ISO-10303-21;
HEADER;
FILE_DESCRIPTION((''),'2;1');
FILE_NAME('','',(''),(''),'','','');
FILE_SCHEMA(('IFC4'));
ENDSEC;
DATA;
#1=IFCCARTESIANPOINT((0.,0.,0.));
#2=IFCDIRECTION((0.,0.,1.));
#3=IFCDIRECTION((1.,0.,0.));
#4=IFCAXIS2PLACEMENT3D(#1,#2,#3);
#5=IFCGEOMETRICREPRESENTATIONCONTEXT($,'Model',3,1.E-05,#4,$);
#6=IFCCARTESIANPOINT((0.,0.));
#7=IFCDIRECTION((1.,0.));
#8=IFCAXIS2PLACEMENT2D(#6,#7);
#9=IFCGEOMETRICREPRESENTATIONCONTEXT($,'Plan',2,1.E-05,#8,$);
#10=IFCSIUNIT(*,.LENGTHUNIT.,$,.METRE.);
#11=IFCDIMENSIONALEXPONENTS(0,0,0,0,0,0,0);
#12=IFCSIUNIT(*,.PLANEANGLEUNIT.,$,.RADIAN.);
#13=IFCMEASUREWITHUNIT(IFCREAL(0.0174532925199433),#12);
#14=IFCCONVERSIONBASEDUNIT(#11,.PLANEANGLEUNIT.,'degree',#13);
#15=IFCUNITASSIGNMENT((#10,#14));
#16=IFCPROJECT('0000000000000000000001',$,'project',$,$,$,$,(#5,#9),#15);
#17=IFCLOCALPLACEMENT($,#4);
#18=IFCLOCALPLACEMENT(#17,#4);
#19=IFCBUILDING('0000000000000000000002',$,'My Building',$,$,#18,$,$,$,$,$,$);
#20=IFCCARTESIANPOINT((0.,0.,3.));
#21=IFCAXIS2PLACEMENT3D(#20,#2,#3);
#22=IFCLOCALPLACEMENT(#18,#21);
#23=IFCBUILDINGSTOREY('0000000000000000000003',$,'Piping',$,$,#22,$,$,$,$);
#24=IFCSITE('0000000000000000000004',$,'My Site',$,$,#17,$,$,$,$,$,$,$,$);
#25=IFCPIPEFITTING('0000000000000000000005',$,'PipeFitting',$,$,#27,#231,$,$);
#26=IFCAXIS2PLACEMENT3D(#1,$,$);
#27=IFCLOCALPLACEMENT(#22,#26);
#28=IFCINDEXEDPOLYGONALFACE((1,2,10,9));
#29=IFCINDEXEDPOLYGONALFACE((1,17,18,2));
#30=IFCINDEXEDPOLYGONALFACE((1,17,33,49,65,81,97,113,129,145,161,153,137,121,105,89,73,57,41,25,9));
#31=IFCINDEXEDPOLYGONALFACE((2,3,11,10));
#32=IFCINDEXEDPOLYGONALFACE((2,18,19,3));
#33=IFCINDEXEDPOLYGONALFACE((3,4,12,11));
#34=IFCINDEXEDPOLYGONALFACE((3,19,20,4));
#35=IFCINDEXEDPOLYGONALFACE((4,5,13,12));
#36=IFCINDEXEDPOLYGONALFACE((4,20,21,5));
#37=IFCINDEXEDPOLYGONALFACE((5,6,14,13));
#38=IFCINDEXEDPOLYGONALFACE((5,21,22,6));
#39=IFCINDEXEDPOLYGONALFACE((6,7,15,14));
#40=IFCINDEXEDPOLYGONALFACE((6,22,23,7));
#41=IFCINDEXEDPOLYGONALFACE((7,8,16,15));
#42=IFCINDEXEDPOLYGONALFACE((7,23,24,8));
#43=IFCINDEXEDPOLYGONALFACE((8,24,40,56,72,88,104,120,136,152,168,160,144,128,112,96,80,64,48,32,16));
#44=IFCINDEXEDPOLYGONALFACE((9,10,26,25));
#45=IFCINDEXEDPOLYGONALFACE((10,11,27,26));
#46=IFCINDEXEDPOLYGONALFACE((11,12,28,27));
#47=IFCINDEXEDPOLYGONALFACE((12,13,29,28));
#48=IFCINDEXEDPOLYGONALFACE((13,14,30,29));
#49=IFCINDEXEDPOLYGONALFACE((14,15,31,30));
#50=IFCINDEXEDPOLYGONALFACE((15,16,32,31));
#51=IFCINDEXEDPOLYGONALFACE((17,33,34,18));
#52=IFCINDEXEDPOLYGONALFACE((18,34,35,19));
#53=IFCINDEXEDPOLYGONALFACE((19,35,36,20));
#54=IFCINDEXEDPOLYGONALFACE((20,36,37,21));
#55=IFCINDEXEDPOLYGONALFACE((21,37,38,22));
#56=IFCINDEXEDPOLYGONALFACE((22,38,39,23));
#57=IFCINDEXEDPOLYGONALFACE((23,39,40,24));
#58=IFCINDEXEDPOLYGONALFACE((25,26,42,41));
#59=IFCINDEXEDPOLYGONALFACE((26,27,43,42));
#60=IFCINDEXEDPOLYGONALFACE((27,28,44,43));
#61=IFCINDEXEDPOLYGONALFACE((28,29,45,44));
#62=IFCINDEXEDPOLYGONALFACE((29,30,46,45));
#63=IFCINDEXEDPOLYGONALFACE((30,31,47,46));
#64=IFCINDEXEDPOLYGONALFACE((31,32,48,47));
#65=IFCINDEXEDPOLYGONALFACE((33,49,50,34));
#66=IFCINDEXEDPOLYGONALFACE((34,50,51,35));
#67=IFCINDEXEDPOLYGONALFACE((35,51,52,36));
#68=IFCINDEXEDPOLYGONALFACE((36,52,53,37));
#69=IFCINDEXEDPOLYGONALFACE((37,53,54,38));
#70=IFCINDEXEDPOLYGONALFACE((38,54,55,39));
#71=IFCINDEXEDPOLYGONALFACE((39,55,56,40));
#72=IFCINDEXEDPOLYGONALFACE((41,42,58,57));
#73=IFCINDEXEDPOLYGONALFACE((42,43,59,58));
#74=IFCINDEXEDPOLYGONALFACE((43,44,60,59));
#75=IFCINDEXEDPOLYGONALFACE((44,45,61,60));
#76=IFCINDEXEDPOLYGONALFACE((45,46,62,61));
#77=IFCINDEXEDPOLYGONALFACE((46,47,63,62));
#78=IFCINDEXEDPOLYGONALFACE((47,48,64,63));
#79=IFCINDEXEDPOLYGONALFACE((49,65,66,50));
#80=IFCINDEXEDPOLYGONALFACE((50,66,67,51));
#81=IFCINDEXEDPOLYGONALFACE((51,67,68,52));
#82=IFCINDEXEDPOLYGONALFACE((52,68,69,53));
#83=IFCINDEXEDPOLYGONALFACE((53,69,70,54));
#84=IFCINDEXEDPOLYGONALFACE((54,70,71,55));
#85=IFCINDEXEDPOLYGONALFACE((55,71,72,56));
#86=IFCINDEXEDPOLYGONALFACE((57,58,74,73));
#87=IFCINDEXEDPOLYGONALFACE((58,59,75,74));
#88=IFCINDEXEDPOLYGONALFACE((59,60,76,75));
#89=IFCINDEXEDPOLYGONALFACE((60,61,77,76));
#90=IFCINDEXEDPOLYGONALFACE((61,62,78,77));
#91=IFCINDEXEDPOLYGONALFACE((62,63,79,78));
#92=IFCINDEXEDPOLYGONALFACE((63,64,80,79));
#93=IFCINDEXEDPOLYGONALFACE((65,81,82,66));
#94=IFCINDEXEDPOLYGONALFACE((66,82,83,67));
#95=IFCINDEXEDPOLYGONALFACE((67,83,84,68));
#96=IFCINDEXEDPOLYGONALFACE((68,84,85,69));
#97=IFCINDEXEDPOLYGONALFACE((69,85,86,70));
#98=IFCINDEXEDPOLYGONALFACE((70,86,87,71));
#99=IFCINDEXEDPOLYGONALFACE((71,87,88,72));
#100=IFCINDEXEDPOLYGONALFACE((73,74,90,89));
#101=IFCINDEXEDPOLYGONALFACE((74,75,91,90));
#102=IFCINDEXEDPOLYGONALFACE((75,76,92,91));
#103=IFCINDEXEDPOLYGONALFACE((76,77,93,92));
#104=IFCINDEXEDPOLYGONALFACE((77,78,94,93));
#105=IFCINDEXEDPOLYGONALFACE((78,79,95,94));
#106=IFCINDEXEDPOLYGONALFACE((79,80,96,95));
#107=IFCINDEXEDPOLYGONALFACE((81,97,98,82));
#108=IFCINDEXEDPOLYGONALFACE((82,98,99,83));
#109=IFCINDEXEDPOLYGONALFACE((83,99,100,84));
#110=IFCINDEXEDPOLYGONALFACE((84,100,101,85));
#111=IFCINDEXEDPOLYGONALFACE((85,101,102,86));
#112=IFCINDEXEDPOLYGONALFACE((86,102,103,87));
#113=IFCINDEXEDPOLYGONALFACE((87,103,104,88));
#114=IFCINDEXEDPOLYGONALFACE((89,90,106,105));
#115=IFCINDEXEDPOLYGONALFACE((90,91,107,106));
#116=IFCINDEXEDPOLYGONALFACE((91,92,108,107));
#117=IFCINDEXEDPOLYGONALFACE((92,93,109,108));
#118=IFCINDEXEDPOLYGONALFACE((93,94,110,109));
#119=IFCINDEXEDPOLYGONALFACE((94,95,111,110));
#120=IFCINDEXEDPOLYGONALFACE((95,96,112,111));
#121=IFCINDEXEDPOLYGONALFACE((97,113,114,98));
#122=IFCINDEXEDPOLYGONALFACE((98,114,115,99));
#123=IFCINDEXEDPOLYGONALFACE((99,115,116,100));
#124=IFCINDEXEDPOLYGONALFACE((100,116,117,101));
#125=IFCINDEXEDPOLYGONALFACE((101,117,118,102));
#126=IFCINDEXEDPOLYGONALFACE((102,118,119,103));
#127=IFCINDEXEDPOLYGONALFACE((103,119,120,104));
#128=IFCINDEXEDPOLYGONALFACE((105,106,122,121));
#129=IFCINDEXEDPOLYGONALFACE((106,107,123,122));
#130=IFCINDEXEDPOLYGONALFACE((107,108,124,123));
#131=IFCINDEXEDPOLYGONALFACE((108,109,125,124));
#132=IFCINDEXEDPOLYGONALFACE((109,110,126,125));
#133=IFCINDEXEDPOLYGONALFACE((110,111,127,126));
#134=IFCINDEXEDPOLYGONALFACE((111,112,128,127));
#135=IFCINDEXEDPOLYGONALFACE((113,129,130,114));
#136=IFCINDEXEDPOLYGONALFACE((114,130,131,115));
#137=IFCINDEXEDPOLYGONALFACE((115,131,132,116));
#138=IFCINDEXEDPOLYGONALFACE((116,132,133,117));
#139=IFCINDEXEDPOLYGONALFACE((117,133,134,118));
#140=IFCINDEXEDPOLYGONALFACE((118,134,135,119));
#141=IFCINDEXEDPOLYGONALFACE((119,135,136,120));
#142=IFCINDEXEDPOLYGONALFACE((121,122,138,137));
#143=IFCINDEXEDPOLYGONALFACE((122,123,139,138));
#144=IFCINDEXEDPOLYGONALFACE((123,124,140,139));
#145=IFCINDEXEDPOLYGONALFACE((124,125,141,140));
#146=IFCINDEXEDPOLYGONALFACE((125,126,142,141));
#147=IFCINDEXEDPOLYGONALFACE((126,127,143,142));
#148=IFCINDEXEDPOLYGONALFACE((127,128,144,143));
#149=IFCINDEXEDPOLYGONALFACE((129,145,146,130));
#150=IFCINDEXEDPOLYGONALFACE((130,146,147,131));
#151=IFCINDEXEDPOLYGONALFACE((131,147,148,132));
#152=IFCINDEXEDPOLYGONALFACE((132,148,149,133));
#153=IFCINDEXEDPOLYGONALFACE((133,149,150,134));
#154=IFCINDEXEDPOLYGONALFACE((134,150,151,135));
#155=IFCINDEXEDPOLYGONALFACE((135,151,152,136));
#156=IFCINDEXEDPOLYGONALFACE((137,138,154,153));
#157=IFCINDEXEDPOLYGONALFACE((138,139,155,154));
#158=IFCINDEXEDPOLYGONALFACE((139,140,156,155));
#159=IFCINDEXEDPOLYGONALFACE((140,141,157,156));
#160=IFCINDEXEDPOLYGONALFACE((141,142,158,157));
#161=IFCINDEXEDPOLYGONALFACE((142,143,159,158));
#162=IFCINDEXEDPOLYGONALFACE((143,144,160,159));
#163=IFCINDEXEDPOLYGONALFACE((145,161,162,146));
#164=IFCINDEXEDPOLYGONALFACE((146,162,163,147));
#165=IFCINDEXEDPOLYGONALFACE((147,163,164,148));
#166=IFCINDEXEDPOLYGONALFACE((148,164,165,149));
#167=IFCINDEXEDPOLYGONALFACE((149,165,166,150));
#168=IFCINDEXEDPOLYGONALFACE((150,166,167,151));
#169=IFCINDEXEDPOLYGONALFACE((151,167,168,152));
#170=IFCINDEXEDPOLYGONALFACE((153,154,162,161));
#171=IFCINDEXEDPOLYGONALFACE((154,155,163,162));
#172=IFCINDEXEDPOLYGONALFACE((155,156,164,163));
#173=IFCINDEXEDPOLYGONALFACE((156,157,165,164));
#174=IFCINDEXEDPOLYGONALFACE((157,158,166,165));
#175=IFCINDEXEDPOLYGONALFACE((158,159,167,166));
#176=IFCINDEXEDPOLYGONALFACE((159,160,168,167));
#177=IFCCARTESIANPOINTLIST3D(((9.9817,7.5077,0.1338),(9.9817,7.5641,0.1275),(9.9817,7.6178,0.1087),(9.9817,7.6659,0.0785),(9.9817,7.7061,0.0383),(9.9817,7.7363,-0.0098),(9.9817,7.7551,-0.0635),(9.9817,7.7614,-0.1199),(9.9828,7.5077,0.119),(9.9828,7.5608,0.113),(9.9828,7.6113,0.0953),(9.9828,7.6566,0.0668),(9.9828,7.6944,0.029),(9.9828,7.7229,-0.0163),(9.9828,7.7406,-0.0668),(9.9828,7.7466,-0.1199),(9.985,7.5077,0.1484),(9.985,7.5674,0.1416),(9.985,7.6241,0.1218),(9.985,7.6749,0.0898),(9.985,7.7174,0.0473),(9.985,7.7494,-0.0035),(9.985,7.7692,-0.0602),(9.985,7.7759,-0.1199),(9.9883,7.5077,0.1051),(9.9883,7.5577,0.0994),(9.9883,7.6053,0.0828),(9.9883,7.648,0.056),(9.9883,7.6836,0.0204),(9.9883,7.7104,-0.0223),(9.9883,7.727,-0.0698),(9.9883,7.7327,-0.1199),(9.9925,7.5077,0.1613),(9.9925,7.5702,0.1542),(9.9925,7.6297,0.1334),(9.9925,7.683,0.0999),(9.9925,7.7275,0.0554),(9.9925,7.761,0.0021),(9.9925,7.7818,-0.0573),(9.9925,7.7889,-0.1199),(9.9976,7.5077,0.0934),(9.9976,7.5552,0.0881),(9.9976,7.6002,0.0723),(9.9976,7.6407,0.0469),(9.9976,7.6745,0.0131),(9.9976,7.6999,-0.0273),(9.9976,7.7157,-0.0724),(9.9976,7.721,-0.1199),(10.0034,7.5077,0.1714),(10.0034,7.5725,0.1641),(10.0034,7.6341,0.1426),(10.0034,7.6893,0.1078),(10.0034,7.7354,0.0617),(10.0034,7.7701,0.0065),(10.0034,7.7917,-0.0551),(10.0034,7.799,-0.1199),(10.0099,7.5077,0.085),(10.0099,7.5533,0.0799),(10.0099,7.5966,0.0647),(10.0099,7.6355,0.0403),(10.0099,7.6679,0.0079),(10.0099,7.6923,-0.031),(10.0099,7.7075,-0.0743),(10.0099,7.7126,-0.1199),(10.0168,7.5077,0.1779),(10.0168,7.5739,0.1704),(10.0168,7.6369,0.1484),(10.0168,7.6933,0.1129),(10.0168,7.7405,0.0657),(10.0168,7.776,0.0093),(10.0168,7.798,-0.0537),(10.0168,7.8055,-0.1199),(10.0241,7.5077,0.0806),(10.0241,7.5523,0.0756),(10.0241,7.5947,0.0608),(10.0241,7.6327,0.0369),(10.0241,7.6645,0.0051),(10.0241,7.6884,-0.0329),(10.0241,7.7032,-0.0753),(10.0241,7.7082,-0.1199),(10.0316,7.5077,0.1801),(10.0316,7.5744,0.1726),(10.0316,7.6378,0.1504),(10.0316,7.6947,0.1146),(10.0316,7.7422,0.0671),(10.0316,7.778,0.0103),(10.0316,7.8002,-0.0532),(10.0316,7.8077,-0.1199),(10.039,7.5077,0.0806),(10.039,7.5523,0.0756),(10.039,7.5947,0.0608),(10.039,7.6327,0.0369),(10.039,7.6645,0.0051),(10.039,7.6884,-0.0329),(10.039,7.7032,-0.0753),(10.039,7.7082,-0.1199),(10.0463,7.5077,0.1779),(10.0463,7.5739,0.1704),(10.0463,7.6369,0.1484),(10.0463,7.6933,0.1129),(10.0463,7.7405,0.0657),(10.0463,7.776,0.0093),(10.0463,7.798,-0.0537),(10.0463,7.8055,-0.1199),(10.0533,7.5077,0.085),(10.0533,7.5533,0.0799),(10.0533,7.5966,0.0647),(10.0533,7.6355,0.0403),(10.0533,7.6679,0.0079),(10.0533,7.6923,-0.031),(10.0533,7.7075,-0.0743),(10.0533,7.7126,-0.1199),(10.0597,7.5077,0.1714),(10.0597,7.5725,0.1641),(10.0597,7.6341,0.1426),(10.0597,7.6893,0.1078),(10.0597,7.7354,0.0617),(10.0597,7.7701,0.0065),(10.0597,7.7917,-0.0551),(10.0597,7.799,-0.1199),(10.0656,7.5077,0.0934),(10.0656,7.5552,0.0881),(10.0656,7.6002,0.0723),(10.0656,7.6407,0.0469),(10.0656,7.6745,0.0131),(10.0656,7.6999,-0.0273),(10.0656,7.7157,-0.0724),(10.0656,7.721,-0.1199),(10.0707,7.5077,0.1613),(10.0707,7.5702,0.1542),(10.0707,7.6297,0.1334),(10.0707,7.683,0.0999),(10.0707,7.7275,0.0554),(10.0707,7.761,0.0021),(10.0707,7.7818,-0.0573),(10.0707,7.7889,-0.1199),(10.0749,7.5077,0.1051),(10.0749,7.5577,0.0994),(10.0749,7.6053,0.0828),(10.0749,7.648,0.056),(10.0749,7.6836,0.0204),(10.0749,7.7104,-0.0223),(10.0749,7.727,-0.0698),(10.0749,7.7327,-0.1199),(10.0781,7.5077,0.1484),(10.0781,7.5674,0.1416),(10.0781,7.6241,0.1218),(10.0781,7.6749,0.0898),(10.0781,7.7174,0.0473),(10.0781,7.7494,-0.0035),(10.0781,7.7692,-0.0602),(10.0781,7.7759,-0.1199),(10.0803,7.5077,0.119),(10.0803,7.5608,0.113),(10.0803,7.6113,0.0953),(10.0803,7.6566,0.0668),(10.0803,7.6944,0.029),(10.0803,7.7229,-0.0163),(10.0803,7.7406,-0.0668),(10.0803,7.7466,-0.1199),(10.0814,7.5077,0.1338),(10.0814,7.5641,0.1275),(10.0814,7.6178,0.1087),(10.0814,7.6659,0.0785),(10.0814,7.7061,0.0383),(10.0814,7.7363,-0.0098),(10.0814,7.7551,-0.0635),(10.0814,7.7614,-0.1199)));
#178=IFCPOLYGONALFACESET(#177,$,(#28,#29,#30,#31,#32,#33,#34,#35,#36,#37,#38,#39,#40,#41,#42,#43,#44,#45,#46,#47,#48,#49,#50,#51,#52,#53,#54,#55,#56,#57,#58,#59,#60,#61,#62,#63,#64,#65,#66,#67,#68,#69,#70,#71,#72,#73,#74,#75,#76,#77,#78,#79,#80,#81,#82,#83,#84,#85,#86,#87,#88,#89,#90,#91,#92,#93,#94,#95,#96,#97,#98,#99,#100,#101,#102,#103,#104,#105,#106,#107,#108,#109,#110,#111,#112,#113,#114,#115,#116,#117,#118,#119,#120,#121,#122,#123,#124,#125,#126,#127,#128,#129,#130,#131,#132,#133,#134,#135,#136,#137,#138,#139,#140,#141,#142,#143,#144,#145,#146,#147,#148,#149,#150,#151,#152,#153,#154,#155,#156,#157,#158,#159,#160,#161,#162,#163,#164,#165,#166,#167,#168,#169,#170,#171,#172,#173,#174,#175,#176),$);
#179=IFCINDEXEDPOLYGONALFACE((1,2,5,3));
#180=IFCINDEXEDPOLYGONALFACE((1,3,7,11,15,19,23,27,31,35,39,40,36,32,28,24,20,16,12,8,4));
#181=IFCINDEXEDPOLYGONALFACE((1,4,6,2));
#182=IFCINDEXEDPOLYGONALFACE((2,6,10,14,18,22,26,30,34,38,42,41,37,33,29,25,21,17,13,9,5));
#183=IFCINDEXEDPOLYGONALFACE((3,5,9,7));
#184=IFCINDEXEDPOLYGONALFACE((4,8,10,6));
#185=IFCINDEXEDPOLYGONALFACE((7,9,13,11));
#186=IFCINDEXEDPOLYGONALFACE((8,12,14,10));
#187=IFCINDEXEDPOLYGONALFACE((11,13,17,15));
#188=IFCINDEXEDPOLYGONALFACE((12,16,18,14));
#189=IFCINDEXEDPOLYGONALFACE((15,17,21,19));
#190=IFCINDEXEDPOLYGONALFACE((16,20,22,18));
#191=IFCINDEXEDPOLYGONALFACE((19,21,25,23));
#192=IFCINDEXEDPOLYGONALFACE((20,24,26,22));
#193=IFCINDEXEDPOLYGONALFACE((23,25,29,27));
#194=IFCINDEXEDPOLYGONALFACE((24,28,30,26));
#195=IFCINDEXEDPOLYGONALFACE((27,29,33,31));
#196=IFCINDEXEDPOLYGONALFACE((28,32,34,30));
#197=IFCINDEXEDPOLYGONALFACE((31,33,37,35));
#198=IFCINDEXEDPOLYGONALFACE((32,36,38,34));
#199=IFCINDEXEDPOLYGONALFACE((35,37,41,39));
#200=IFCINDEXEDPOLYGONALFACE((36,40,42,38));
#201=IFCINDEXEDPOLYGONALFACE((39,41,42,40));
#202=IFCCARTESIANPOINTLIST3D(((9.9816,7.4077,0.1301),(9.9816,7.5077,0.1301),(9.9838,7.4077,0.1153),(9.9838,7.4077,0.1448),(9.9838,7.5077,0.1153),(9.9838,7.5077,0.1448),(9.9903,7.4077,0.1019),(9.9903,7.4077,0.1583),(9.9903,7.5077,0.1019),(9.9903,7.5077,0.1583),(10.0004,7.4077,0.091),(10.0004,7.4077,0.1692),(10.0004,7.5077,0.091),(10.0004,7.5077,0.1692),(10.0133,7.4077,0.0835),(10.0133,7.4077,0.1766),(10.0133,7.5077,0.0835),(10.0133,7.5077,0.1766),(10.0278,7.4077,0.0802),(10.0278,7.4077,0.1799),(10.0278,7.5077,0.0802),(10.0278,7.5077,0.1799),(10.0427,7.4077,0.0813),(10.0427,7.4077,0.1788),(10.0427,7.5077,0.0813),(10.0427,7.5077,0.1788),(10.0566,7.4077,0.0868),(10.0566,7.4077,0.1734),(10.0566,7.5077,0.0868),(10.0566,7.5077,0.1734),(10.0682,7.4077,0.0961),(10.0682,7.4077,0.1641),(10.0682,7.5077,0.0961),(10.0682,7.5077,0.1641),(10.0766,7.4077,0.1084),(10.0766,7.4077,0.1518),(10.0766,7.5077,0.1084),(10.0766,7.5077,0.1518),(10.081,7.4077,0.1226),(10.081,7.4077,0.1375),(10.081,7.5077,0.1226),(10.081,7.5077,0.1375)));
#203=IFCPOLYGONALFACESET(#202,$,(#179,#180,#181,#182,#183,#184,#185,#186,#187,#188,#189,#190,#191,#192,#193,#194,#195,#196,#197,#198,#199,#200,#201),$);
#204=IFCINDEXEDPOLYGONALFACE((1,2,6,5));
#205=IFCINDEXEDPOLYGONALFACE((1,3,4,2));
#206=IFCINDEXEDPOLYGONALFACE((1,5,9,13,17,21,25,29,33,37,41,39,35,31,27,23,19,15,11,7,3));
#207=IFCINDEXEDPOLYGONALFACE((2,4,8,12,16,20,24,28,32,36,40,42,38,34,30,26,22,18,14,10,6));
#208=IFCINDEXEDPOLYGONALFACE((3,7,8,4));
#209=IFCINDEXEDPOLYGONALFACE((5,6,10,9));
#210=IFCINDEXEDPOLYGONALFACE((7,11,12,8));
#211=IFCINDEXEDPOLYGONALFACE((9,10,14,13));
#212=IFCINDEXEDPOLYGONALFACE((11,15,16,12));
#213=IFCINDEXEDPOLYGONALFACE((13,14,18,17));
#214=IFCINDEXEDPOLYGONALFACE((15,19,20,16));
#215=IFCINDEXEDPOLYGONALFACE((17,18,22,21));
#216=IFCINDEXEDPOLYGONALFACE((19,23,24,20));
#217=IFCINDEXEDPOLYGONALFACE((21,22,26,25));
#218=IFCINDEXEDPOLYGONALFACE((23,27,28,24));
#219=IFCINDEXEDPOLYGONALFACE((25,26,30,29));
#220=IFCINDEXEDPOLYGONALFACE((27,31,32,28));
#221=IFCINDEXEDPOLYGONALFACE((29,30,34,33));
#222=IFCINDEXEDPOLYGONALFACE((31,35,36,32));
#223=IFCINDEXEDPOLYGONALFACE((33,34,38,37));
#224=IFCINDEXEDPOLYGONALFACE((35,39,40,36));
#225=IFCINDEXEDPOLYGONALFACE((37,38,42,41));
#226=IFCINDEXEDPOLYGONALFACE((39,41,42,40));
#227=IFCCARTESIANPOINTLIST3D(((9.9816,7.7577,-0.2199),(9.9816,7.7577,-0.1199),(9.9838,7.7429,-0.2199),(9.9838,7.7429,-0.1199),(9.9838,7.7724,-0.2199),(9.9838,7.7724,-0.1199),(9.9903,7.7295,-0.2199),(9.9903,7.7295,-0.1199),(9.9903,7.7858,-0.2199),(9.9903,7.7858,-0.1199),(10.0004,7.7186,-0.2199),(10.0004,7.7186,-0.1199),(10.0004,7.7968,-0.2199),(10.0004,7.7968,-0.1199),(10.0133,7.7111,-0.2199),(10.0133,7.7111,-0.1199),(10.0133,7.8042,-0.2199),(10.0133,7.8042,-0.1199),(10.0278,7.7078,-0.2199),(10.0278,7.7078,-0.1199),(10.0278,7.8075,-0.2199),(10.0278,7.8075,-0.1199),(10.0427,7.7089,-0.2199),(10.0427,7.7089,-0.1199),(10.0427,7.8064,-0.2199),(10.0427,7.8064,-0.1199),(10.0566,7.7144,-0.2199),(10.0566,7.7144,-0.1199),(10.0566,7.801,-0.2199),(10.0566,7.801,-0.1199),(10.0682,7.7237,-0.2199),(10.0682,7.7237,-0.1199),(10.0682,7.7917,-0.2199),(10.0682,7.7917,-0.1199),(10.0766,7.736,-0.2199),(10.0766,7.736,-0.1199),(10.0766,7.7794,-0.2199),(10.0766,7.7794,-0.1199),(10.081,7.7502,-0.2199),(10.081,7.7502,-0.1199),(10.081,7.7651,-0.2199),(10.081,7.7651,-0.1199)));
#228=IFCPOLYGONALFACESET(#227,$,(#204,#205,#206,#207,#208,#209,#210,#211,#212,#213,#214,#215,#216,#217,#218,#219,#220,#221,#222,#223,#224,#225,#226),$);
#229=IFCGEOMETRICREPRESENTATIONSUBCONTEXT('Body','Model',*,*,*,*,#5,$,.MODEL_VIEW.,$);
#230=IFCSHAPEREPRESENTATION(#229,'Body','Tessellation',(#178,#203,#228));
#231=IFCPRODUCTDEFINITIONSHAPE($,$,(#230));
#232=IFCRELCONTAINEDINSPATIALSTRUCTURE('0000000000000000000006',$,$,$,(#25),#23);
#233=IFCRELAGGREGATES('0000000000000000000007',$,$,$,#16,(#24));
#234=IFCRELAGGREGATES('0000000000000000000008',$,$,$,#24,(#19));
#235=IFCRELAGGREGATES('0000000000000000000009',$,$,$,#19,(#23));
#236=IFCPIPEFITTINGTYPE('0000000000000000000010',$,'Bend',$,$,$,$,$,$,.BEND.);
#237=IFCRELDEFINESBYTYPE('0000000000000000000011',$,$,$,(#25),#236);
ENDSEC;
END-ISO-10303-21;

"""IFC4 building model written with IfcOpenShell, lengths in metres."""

from ifc_helpers import new_model, entity, si_unit, converted_unit, frame, origin_with_axes, origin_2d_with_axis, place, context, subcontext, project, spatial, circle, extrude, source, transform, mapped, type_object, type_shapes, element, save


model = new_model("IFC4")

# Units and contexts
model_context = context("Model", 3, precision=1e-05, world=origin_with_axes())
plan_context = context("Plan", 2, precision=1e-05, world=origin_2d_with_axis())
body_context = subcontext(model_context, "Body", "Model", "MODEL_VIEW")
ifc_project = project(units=[si_unit("LENGTHUNIT", "METRE"), converted_unit("PLANEANGLEUNIT", "degree", entity("IfcReal", 0.0174532925199433), si_unit("PLANEANGLEUNIT", "RADIAN"), dimensions=[0, 0, 0, 0, 0, 0, 0])], contexts=[model_context, plan_context])

# Site, building, storey
site_placement = place(None, origin_with_axes())
site = spatial("IfcSite", under=ifc_project, at=site_placement, Name="My Site")
building_placement = place(site_placement, origin_with_axes())
building = spatial("IfcBuilding", under=site, at=building_placement, Name="My Building")
storey_placement = place(building_placement, frame((0.0, 0.0, 3.0), z_axis=(0.0, 0.0, 1.0), x_axis=(1.0, 0.0, 0.0)))
storey = spatial("IfcBuildingStorey", under=building, at=storey_placement, Name="Piping")

# Pipe fitting
pipe_fitting_type_1 = type_object("IfcPipeFittingType", Name="Bend", PredefinedType="BEND")
shared_shape_1 = source(origin_with_axes(), body_context, "Body", "SolidModel", [
    entity("IfcSweptDiskSolid", entity("IfcIndexedPolyCurve", entity("IfcCartesianPointList3D", [[0.0, 0.0, 0.1], [0.0, -0.0732, 0.2768], [0.0, -0.25, 0.35]]), [entity("IfcArcIndex", [1, 2, 3])]), 0.05),
    extrude(circle(Radius=0.05), origin_with_axes(), (0.0, 0.0, 1.0), 0.1),
    extrude(circle(Radius=0.05), frame((0.0, -0.25, 0.35), z_axis=(0.0, -1.0, -0.000015), x_axis=(1.0, 0.0, 0.0)), (0.0, 0.0, 1.0), 0.1),
])
type_shapes(pipe_fitting_type_1, [shared_shape_1])
for number, where, z_axis, x_axis, name in (
    (1, (10.0316, 7.4077, 0.1301), (0.0, 1.0, 0.000015), (-1.0, 0.0, 0.0), "PipeFitting"),
):
    element("IfcPipeFitting", number, at=place(storey_placement, frame(where, z_axis=z_axis, x_axis=x_axis)), inside=storey, type_object=pipe_fitting_type_1, Name=name, context=body_context, shape_type="MappedRepresentation", body=[
        mapped(shared_shape_1, transform((0.0, 0.0, 0.0), x_axis=(1.0, 0.0, 0.0), y_axis=(0.0, 1.0, 0.0), z_axis=(0.0, 0.0, 1.0), scale=1.0)),
    ])

save(model, "model.ifc")
